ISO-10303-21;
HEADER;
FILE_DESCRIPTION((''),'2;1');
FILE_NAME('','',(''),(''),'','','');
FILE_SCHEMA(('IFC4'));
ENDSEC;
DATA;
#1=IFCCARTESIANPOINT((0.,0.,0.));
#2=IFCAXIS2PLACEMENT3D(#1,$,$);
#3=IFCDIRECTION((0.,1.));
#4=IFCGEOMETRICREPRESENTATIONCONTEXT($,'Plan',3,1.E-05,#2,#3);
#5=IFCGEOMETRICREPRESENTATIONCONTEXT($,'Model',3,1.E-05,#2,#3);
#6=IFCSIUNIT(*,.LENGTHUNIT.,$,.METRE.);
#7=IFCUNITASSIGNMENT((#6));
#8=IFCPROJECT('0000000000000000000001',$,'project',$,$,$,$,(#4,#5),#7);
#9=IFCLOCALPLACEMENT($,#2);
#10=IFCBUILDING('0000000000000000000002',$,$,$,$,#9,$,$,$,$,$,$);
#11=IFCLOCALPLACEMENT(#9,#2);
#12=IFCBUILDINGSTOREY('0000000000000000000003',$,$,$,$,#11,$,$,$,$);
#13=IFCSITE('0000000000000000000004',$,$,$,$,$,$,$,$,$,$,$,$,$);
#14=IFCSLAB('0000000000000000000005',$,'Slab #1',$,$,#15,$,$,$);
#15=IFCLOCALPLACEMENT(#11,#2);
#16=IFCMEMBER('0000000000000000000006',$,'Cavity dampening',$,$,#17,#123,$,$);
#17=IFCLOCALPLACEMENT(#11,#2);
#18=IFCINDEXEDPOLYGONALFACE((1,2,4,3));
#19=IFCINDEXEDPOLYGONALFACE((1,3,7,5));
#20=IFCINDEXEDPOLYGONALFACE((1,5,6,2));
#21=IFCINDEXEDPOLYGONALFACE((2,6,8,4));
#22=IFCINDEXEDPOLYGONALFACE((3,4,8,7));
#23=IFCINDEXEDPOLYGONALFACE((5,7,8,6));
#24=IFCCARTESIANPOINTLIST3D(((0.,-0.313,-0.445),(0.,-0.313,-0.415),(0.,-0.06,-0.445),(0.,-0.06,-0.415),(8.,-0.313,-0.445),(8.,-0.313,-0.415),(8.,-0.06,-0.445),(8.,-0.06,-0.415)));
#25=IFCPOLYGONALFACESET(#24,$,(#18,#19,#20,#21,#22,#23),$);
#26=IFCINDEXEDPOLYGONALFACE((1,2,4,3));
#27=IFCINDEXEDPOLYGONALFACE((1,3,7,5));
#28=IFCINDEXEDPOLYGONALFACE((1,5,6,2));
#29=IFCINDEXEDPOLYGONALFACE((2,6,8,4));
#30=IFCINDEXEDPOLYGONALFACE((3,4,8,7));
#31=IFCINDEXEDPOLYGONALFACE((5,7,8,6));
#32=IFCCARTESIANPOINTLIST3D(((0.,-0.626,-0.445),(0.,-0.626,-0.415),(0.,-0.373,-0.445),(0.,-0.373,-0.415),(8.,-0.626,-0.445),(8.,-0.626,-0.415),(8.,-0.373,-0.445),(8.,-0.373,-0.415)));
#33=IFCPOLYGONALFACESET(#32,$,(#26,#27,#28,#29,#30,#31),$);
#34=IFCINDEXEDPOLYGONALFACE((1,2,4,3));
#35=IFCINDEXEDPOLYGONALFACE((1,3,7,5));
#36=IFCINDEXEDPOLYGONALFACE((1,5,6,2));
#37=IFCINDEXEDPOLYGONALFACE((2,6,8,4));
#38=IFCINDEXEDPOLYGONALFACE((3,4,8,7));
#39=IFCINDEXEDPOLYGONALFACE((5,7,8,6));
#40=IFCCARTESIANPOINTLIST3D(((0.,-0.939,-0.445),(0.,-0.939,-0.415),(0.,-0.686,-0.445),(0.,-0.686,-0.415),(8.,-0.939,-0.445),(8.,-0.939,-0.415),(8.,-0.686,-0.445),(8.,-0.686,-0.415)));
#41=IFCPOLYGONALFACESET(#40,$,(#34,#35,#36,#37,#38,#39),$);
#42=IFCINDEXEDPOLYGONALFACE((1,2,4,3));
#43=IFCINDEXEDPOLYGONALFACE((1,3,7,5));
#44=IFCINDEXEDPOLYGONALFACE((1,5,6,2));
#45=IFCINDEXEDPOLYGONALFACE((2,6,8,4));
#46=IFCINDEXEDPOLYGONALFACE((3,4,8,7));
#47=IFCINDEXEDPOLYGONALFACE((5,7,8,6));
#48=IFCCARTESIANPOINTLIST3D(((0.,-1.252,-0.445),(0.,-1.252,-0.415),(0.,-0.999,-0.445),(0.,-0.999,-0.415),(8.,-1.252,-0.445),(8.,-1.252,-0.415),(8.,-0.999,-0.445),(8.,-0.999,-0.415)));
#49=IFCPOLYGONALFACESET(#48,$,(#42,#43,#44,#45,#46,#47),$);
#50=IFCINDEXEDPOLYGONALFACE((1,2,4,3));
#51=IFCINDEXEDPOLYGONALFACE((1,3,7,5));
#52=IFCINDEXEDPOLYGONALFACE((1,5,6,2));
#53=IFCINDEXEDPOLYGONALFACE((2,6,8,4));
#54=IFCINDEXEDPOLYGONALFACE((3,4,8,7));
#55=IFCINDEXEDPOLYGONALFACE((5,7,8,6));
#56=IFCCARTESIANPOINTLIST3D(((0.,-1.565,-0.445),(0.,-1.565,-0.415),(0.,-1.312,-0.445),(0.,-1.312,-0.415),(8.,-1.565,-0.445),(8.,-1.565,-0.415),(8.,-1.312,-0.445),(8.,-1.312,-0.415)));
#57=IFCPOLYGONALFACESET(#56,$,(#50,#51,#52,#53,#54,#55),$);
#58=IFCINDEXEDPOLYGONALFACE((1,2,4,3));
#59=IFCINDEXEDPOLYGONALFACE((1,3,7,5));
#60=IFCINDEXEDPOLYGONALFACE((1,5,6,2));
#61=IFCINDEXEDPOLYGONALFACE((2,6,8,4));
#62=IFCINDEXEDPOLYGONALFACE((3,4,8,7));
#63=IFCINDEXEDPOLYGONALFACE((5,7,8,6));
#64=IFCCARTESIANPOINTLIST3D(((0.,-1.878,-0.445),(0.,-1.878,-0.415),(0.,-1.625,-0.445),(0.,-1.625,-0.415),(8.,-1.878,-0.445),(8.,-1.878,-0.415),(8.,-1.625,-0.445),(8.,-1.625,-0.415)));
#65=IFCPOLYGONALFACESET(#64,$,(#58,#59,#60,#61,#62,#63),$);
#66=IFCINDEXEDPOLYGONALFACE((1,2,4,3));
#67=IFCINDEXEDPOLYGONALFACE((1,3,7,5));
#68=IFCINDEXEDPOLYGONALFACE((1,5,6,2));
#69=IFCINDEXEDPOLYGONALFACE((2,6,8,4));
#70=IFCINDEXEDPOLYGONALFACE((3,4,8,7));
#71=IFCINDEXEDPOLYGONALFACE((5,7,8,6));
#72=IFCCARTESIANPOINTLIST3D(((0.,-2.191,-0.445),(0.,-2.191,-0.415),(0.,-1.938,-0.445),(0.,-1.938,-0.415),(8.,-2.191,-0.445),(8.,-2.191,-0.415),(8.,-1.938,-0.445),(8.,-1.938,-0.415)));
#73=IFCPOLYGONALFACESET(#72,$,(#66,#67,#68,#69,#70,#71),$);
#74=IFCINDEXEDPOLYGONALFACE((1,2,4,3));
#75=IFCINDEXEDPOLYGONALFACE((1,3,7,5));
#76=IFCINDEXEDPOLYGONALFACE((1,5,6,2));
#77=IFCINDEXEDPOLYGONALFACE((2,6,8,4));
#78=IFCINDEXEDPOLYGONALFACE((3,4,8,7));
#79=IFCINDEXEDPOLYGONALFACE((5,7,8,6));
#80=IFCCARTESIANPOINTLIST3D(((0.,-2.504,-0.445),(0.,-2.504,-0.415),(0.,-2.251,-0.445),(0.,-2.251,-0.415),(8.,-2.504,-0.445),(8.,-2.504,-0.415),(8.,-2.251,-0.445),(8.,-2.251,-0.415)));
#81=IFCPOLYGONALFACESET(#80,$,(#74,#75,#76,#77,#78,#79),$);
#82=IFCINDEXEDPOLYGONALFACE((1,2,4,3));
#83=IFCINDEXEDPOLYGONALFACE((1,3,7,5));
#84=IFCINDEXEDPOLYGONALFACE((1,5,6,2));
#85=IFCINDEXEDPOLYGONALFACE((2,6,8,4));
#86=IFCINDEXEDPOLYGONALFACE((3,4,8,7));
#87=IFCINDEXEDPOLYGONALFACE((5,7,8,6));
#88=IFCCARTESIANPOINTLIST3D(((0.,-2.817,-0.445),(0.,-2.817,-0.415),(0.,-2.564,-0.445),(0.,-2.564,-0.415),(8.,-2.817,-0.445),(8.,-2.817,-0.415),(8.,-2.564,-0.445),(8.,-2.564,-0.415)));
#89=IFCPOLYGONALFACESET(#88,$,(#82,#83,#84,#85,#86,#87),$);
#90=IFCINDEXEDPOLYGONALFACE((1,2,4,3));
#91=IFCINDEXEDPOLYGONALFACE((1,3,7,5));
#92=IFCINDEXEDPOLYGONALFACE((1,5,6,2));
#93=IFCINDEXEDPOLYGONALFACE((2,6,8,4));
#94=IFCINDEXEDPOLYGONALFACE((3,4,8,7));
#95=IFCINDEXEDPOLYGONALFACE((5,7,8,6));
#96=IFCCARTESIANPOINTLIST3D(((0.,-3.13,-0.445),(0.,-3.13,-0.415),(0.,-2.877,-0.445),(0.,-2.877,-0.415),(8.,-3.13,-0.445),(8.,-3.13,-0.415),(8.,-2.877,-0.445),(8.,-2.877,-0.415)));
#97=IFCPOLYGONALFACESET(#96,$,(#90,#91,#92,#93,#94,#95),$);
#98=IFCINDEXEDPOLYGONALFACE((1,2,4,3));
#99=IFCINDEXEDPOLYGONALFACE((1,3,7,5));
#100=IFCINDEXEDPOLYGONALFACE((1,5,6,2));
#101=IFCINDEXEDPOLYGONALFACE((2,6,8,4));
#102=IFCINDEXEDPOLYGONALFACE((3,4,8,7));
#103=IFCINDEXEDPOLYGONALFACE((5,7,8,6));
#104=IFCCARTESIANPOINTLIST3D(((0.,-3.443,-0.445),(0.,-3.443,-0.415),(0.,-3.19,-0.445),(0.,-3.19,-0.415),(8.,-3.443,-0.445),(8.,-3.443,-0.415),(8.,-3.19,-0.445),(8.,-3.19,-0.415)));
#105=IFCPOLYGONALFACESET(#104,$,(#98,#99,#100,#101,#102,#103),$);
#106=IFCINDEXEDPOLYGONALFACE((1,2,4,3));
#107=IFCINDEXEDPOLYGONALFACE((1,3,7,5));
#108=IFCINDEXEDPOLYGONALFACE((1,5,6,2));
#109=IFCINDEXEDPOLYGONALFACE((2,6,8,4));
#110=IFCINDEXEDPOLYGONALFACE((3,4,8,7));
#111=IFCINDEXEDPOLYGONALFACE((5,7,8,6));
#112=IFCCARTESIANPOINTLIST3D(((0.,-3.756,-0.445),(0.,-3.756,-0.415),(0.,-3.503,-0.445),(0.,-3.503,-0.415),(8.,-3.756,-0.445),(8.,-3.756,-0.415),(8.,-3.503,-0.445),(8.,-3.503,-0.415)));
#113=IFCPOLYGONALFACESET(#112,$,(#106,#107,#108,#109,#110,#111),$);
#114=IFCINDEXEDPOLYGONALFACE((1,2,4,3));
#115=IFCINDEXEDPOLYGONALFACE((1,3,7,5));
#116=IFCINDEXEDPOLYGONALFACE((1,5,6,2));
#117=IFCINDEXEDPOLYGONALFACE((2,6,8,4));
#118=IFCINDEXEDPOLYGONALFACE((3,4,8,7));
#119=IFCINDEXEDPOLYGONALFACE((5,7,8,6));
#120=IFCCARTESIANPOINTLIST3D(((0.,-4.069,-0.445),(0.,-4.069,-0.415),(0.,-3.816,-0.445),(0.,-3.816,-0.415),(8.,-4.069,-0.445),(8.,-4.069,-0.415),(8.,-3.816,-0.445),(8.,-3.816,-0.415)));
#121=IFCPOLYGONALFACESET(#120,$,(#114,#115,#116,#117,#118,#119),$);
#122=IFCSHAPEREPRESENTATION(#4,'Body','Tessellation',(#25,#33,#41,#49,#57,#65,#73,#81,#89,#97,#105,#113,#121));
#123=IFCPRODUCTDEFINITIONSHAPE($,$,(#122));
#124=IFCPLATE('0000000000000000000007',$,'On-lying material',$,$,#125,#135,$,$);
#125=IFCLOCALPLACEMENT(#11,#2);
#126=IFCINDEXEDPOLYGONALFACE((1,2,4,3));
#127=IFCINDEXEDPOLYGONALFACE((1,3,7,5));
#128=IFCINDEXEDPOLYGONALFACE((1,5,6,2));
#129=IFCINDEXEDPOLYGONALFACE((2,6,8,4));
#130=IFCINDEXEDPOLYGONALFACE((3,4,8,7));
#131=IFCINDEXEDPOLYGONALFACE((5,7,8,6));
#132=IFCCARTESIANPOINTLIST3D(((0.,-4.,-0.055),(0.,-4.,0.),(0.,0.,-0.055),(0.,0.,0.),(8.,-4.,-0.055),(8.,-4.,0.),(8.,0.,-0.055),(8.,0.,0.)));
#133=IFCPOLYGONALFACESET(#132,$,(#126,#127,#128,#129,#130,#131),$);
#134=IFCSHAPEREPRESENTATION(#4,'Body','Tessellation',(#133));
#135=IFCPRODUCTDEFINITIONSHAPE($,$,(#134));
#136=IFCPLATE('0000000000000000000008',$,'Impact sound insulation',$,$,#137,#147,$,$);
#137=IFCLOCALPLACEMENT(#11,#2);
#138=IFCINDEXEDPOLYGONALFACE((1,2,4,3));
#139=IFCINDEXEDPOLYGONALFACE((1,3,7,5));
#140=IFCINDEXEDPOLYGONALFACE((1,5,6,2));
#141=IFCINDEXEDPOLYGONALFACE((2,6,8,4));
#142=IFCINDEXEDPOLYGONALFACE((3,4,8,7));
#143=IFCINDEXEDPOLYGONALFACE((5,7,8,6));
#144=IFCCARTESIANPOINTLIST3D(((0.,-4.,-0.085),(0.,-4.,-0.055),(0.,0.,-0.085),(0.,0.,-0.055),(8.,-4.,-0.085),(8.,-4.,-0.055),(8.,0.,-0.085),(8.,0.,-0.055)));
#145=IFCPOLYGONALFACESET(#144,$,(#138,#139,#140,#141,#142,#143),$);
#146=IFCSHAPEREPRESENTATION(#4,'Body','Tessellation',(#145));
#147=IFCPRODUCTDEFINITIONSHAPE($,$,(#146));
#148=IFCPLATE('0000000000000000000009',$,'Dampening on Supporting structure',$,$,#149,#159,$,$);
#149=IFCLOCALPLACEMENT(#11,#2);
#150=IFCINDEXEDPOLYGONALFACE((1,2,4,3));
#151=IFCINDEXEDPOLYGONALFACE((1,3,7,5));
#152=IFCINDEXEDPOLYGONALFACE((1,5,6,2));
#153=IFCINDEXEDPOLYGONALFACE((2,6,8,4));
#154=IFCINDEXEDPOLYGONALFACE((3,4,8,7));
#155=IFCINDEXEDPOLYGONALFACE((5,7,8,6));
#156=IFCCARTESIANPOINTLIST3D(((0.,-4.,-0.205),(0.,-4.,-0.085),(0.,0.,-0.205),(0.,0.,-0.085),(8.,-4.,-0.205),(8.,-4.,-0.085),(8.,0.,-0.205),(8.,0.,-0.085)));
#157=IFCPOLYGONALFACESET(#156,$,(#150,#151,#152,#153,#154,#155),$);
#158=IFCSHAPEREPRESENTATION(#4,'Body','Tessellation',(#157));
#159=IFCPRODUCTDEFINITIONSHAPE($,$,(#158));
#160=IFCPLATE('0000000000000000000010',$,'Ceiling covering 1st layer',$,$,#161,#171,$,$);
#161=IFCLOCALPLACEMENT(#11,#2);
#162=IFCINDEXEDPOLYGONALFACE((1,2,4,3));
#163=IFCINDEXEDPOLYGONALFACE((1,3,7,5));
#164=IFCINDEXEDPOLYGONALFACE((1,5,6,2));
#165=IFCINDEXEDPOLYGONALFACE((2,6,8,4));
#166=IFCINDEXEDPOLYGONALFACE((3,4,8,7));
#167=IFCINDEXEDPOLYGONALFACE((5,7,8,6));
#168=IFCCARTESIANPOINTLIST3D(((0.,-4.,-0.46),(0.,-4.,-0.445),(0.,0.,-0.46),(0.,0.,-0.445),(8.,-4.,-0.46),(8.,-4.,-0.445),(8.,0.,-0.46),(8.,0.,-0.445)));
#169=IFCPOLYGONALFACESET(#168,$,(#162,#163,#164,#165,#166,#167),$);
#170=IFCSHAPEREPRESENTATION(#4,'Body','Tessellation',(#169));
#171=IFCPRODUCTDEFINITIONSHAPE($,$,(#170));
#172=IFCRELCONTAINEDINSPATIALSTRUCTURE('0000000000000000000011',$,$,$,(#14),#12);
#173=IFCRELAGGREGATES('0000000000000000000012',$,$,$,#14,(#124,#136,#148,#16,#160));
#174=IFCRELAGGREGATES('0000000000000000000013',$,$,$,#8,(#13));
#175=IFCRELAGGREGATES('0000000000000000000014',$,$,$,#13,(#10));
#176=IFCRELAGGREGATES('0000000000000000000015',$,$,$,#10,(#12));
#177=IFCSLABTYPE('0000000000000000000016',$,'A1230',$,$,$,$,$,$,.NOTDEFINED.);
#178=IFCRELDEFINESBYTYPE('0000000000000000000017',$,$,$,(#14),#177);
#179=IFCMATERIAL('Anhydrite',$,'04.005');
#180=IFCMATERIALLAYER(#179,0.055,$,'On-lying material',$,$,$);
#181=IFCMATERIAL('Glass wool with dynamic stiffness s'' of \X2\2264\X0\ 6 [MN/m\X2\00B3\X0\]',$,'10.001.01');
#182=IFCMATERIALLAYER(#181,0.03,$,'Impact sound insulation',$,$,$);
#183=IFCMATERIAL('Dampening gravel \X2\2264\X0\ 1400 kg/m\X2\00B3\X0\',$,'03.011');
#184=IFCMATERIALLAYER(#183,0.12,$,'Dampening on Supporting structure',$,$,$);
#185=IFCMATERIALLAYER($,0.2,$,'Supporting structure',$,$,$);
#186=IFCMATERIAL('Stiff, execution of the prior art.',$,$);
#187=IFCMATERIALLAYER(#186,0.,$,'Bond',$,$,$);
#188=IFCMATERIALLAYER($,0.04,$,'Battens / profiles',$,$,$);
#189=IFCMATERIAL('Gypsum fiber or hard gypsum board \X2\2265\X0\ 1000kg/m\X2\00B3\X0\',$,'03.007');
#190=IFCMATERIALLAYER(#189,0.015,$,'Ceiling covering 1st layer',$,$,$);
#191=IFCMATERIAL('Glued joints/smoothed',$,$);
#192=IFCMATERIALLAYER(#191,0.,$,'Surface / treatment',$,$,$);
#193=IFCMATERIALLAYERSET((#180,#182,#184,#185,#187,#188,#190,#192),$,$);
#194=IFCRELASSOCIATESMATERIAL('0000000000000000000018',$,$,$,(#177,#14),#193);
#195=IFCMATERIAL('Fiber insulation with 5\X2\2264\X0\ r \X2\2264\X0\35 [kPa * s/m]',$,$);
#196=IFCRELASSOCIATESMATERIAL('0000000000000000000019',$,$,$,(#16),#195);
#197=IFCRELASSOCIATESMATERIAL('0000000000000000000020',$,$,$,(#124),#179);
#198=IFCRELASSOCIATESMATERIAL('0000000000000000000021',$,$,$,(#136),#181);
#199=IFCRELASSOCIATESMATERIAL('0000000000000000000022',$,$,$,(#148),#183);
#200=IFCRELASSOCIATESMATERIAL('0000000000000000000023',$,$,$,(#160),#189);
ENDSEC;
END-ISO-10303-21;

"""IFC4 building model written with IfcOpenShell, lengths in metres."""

from ifc_helpers import new_model, si_unit, direction, frame, frame_2d, origin, origin_with_axes, place, context, project, spatial, rectangle, extrude, material, layer, layer_set, type_object, element, aggregate, save


model = new_model("IFC4")

# Units and contexts
plan_context = context("Plan", 3, precision=1e-05, world=origin(), true_north=direction((0.0, 1.0)))
model_context = context("Model", 3, precision=1e-05, world=origin(), true_north=direction((0.0, 1.0)))
ifc_project = project(units=[si_unit("LENGTHUNIT", "METRE")], contexts=[plan_context, model_context])

# Site, building, storey
site = spatial("IfcSite", under=ifc_project)
building_placement = place(None, origin())
building = spatial("IfcBuilding", under=site, at=building_placement)
storey_placement = place(building_placement, origin())
storey = spatial("IfcBuildingStorey", under=building, at=storey_placement)

# Slab, member, plates
ifc_material_1 = material(Name="Anhydrite", Category="04.005")
ifc_layer_1 = layer(ifc_material_1, 0.055, Name="On-lying material")
ifc_material_2 = material(Name="Glass wool with dynamic stiffness s' of ≤ 6 [MN/m³]", Category="10.001.01")
ifc_layer_2 = layer(ifc_material_2, 0.03, Name="Impact sound insulation")
ifc_material_3 = material(Name="Dampening gravel ≤ 1400 kg/m³", Category="03.011")
ifc_layer_3 = layer(ifc_material_3, 0.12, Name="Dampening on Supporting structure")
ifc_layer_4 = layer(None, 0.2, Name="Supporting structure")
ifc_material_4 = material(Name="Stiff, execution of the prior art.")
ifc_layer_5 = layer(ifc_material_4, 0.0, Name="Bond")
ifc_layer_6 = layer(None, 0.04, Name="Battens / profiles")
ifc_material_5 = material(Name="Gypsum fiber or hard gypsum board ≥ 1000kg/m³", Category="03.007")
ifc_layer_7 = layer(ifc_material_5, 0.015, Name="Ceiling covering 1st layer")
ifc_material_6 = material(Name="Glued joints/smoothed")
ifc_layer_8 = layer(ifc_material_6, 0.0, Name="Surface / treatment")
ifc_layer_set = layer_set([ifc_layer_1, ifc_layer_2, ifc_layer_3, ifc_layer_4, ifc_layer_5, ifc_layer_6, ifc_layer_7, ifc_layer_8])
slab_type = type_object("IfcSlabType", Name="A1230", PredefinedType="NOTDEFINED", material=ifc_layer_set)
slab_placement = place(None, frame((0.0, 0.0, 0.0), z_axis=(0.0, 0.0, -1.0), x_axis=(1.0, 0.0, 0.0)))
slab = element("IfcSlab", 1, at=slab_placement, inside=storey, type_object=slab_type, material=ifc_layer_set, Name="Slab #1")
ifc_material_7 = material(Name="Fiber insulation with 5≤ r ≤35 [kPa * s/m]")
member_1_placement = place(slab_placement, origin())
member_1 = element("IfcMember", 2, at=member_1_placement, material=ifc_material_7, Name="Cavity dampening", context=plan_context, shape_type="SweptSolid", body=[
    extrude(rectangle(XDim=0.253, YDim=0.03, at=frame_2d((0.1265, 0.015), x_axis=(1.0, 0.0))), frame((0.0, 0.06, 0.415), z_axis=(1.0, 0.0, 0.0), x_axis=(0.0, 1.0, 0.0)), (0.0, 0.0, 1.0), 8.0),
    extrude(rectangle(XDim=0.253, YDim=0.03, at=frame_2d((0.1265, 0.015), x_axis=(1.0, 0.0))), frame((0.0, 0.373, 0.415), z_axis=(1.0, 0.0, 0.0), x_axis=(0.0, 1.0, 0.0)), (0.0, 0.0, 1.0), 8.0),
    extrude(rectangle(XDim=0.253, YDim=0.03, at=frame_2d((0.1265, 0.015), x_axis=(1.0, 0.0))), frame((0.0, 0.686, 0.415), z_axis=(1.0, 0.0, 0.0), x_axis=(0.0, 1.0, 0.0)), (0.0, 0.0, 1.0), 8.0),
    extrude(rectangle(XDim=0.253, YDim=0.03, at=frame_2d((0.1265, 0.015), x_axis=(1.0, 0.0))), frame((0.0, 0.999, 0.415), z_axis=(1.0, 0.0, 0.0), x_axis=(0.0, 1.0, 0.0)), (0.0, 0.0, 1.0), 8.0),
    extrude(rectangle(XDim=0.253, YDim=0.03, at=frame_2d((0.1265, 0.015), x_axis=(1.0, 0.0))), frame((0.0, 1.312, 0.415), z_axis=(1.0, 0.0, 0.0), x_axis=(0.0, 1.0, 0.0)), (0.0, 0.0, 1.0), 8.0),
    extrude(rectangle(XDim=0.253, YDim=0.03, at=frame_2d((0.1265, 0.015), x_axis=(1.0, 0.0))), frame((0.0, 1.625, 0.415), z_axis=(1.0, 0.0, 0.0), x_axis=(0.0, 1.0, 0.0)), (0.0, 0.0, 1.0), 8.0),
    extrude(rectangle(XDim=0.253, YDim=0.03, at=frame_2d((0.1265, 0.015), x_axis=(1.0, 0.0))), frame((0.0, 1.938, 0.415), z_axis=(1.0, 0.0, 0.0), x_axis=(0.0, 1.0, 0.0)), (0.0, 0.0, 1.0), 8.0),
    extrude(rectangle(XDim=0.253, YDim=0.03, at=frame_2d((0.1265, 0.015), x_axis=(1.0, 0.0))), frame((0.0, 2.251, 0.415), z_axis=(1.0, 0.0, 0.0), x_axis=(0.0, 1.0, 0.0)), (0.0, 0.0, 1.0), 8.0),
    extrude(rectangle(XDim=0.253, YDim=0.03, at=frame_2d((0.1265, 0.015), x_axis=(1.0, 0.0))), frame((0.0, 2.564, 0.415), z_axis=(1.0, 0.0, 0.0), x_axis=(0.0, 1.0, 0.0)), (0.0, 0.0, 1.0), 8.0),
    extrude(rectangle(XDim=0.253, YDim=0.03, at=frame_2d((0.1265, 0.015), x_axis=(1.0, 0.0))), frame((0.0, 2.877, 0.415), z_axis=(1.0, 0.0, 0.0), x_axis=(0.0, 1.0, 0.0)), (0.0, 0.0, 1.0), 8.0),
    extrude(rectangle(XDim=0.253, YDim=0.03, at=frame_2d((0.1265, 0.015), x_axis=(1.0, 0.0))), frame((0.0, 3.19, 0.415), z_axis=(1.0, 0.0, 0.0), x_axis=(0.0, 1.0, 0.0)), (0.0, 0.0, 1.0), 8.0),
    extrude(rectangle(XDim=0.253, YDim=0.03, at=frame_2d((0.1265, 0.015), x_axis=(1.0, 0.0))), frame((0.0, 3.503, 0.415), z_axis=(1.0, 0.0, 0.0), x_axis=(0.0, 1.0, 0.0)), (0.0, 0.0, 1.0), 8.0),
    extrude(rectangle(XDim=0.253, YDim=0.03, at=frame_2d((0.1265, 0.015), x_axis=(1.0, 0.0))), frame((0.0, 3.816, 0.415), z_axis=(1.0, 0.0, 0.0), x_axis=(0.0, 1.0, 0.0)), (0.0, 0.0, 1.0), 8.0),
])
plate_1_placement = place(slab_placement, origin())
plate_1 = element("IfcPlate", 3, at=plate_1_placement, material=ifc_material_1, Name="On-lying material", context=plan_context, shape_type="SweptSolid", body=[
    extrude(rectangle(XDim=8.0, YDim=4.0, at=frame_2d((4.0, 2.0), x_axis=(1.0, 0.0))), origin_with_axes(), (0.0, 0.0, 1.0), 0.055),
])
plate_2_placement = place(slab_placement, origin())
plate_2 = element("IfcPlate", 4, at=plate_2_placement, material=ifc_material_2, Name="Impact sound insulation", context=plan_context, shape_type="SweptSolid", body=[
    extrude(rectangle(XDim=8.0, YDim=4.0, at=frame_2d((4.0, 2.0), x_axis=(1.0, 0.0))), frame((0.0, 0.0, 0.055), z_axis=(0.0, 0.0, 1.0), x_axis=(1.0, 0.0, 0.0)), (0.0, 0.0, 1.0), 0.03),
])
plate_3_placement = place(slab_placement, origin())
plate_3 = element("IfcPlate", 5, at=plate_3_placement, material=ifc_material_3, Name="Dampening on Supporting structure", context=plan_context, shape_type="SweptSolid", body=[
    extrude(rectangle(XDim=8.0, YDim=4.0, at=frame_2d((4.0, 2.0), x_axis=(1.0, 0.0))), frame((0.0, 0.0, 0.085), z_axis=(0.0, 0.0, 1.0), x_axis=(1.0, 0.0, 0.0)), (0.0, 0.0, 1.0), 0.12),
])
plate_4_placement = place(slab_placement, origin())
plate_4 = element("IfcPlate", 6, at=plate_4_placement, material=ifc_material_5, Name="Ceiling covering 1st layer", context=plan_context, shape_type="SweptSolid", body=[
    extrude(rectangle(XDim=8.0, YDim=4.0, at=frame_2d((4.0, 2.0), x_axis=(1.0, 0.0))), frame((0.0, 0.0, 0.445), z_axis=(0.0, 0.0, 1.0), x_axis=(1.0, 0.0, 0.0)), (0.0, 0.0, 1.0), 0.015),
])
aggregate(slab, [plate_1, plate_2, plate_3, member_1, plate_4])

save(model, "model.ifc")
